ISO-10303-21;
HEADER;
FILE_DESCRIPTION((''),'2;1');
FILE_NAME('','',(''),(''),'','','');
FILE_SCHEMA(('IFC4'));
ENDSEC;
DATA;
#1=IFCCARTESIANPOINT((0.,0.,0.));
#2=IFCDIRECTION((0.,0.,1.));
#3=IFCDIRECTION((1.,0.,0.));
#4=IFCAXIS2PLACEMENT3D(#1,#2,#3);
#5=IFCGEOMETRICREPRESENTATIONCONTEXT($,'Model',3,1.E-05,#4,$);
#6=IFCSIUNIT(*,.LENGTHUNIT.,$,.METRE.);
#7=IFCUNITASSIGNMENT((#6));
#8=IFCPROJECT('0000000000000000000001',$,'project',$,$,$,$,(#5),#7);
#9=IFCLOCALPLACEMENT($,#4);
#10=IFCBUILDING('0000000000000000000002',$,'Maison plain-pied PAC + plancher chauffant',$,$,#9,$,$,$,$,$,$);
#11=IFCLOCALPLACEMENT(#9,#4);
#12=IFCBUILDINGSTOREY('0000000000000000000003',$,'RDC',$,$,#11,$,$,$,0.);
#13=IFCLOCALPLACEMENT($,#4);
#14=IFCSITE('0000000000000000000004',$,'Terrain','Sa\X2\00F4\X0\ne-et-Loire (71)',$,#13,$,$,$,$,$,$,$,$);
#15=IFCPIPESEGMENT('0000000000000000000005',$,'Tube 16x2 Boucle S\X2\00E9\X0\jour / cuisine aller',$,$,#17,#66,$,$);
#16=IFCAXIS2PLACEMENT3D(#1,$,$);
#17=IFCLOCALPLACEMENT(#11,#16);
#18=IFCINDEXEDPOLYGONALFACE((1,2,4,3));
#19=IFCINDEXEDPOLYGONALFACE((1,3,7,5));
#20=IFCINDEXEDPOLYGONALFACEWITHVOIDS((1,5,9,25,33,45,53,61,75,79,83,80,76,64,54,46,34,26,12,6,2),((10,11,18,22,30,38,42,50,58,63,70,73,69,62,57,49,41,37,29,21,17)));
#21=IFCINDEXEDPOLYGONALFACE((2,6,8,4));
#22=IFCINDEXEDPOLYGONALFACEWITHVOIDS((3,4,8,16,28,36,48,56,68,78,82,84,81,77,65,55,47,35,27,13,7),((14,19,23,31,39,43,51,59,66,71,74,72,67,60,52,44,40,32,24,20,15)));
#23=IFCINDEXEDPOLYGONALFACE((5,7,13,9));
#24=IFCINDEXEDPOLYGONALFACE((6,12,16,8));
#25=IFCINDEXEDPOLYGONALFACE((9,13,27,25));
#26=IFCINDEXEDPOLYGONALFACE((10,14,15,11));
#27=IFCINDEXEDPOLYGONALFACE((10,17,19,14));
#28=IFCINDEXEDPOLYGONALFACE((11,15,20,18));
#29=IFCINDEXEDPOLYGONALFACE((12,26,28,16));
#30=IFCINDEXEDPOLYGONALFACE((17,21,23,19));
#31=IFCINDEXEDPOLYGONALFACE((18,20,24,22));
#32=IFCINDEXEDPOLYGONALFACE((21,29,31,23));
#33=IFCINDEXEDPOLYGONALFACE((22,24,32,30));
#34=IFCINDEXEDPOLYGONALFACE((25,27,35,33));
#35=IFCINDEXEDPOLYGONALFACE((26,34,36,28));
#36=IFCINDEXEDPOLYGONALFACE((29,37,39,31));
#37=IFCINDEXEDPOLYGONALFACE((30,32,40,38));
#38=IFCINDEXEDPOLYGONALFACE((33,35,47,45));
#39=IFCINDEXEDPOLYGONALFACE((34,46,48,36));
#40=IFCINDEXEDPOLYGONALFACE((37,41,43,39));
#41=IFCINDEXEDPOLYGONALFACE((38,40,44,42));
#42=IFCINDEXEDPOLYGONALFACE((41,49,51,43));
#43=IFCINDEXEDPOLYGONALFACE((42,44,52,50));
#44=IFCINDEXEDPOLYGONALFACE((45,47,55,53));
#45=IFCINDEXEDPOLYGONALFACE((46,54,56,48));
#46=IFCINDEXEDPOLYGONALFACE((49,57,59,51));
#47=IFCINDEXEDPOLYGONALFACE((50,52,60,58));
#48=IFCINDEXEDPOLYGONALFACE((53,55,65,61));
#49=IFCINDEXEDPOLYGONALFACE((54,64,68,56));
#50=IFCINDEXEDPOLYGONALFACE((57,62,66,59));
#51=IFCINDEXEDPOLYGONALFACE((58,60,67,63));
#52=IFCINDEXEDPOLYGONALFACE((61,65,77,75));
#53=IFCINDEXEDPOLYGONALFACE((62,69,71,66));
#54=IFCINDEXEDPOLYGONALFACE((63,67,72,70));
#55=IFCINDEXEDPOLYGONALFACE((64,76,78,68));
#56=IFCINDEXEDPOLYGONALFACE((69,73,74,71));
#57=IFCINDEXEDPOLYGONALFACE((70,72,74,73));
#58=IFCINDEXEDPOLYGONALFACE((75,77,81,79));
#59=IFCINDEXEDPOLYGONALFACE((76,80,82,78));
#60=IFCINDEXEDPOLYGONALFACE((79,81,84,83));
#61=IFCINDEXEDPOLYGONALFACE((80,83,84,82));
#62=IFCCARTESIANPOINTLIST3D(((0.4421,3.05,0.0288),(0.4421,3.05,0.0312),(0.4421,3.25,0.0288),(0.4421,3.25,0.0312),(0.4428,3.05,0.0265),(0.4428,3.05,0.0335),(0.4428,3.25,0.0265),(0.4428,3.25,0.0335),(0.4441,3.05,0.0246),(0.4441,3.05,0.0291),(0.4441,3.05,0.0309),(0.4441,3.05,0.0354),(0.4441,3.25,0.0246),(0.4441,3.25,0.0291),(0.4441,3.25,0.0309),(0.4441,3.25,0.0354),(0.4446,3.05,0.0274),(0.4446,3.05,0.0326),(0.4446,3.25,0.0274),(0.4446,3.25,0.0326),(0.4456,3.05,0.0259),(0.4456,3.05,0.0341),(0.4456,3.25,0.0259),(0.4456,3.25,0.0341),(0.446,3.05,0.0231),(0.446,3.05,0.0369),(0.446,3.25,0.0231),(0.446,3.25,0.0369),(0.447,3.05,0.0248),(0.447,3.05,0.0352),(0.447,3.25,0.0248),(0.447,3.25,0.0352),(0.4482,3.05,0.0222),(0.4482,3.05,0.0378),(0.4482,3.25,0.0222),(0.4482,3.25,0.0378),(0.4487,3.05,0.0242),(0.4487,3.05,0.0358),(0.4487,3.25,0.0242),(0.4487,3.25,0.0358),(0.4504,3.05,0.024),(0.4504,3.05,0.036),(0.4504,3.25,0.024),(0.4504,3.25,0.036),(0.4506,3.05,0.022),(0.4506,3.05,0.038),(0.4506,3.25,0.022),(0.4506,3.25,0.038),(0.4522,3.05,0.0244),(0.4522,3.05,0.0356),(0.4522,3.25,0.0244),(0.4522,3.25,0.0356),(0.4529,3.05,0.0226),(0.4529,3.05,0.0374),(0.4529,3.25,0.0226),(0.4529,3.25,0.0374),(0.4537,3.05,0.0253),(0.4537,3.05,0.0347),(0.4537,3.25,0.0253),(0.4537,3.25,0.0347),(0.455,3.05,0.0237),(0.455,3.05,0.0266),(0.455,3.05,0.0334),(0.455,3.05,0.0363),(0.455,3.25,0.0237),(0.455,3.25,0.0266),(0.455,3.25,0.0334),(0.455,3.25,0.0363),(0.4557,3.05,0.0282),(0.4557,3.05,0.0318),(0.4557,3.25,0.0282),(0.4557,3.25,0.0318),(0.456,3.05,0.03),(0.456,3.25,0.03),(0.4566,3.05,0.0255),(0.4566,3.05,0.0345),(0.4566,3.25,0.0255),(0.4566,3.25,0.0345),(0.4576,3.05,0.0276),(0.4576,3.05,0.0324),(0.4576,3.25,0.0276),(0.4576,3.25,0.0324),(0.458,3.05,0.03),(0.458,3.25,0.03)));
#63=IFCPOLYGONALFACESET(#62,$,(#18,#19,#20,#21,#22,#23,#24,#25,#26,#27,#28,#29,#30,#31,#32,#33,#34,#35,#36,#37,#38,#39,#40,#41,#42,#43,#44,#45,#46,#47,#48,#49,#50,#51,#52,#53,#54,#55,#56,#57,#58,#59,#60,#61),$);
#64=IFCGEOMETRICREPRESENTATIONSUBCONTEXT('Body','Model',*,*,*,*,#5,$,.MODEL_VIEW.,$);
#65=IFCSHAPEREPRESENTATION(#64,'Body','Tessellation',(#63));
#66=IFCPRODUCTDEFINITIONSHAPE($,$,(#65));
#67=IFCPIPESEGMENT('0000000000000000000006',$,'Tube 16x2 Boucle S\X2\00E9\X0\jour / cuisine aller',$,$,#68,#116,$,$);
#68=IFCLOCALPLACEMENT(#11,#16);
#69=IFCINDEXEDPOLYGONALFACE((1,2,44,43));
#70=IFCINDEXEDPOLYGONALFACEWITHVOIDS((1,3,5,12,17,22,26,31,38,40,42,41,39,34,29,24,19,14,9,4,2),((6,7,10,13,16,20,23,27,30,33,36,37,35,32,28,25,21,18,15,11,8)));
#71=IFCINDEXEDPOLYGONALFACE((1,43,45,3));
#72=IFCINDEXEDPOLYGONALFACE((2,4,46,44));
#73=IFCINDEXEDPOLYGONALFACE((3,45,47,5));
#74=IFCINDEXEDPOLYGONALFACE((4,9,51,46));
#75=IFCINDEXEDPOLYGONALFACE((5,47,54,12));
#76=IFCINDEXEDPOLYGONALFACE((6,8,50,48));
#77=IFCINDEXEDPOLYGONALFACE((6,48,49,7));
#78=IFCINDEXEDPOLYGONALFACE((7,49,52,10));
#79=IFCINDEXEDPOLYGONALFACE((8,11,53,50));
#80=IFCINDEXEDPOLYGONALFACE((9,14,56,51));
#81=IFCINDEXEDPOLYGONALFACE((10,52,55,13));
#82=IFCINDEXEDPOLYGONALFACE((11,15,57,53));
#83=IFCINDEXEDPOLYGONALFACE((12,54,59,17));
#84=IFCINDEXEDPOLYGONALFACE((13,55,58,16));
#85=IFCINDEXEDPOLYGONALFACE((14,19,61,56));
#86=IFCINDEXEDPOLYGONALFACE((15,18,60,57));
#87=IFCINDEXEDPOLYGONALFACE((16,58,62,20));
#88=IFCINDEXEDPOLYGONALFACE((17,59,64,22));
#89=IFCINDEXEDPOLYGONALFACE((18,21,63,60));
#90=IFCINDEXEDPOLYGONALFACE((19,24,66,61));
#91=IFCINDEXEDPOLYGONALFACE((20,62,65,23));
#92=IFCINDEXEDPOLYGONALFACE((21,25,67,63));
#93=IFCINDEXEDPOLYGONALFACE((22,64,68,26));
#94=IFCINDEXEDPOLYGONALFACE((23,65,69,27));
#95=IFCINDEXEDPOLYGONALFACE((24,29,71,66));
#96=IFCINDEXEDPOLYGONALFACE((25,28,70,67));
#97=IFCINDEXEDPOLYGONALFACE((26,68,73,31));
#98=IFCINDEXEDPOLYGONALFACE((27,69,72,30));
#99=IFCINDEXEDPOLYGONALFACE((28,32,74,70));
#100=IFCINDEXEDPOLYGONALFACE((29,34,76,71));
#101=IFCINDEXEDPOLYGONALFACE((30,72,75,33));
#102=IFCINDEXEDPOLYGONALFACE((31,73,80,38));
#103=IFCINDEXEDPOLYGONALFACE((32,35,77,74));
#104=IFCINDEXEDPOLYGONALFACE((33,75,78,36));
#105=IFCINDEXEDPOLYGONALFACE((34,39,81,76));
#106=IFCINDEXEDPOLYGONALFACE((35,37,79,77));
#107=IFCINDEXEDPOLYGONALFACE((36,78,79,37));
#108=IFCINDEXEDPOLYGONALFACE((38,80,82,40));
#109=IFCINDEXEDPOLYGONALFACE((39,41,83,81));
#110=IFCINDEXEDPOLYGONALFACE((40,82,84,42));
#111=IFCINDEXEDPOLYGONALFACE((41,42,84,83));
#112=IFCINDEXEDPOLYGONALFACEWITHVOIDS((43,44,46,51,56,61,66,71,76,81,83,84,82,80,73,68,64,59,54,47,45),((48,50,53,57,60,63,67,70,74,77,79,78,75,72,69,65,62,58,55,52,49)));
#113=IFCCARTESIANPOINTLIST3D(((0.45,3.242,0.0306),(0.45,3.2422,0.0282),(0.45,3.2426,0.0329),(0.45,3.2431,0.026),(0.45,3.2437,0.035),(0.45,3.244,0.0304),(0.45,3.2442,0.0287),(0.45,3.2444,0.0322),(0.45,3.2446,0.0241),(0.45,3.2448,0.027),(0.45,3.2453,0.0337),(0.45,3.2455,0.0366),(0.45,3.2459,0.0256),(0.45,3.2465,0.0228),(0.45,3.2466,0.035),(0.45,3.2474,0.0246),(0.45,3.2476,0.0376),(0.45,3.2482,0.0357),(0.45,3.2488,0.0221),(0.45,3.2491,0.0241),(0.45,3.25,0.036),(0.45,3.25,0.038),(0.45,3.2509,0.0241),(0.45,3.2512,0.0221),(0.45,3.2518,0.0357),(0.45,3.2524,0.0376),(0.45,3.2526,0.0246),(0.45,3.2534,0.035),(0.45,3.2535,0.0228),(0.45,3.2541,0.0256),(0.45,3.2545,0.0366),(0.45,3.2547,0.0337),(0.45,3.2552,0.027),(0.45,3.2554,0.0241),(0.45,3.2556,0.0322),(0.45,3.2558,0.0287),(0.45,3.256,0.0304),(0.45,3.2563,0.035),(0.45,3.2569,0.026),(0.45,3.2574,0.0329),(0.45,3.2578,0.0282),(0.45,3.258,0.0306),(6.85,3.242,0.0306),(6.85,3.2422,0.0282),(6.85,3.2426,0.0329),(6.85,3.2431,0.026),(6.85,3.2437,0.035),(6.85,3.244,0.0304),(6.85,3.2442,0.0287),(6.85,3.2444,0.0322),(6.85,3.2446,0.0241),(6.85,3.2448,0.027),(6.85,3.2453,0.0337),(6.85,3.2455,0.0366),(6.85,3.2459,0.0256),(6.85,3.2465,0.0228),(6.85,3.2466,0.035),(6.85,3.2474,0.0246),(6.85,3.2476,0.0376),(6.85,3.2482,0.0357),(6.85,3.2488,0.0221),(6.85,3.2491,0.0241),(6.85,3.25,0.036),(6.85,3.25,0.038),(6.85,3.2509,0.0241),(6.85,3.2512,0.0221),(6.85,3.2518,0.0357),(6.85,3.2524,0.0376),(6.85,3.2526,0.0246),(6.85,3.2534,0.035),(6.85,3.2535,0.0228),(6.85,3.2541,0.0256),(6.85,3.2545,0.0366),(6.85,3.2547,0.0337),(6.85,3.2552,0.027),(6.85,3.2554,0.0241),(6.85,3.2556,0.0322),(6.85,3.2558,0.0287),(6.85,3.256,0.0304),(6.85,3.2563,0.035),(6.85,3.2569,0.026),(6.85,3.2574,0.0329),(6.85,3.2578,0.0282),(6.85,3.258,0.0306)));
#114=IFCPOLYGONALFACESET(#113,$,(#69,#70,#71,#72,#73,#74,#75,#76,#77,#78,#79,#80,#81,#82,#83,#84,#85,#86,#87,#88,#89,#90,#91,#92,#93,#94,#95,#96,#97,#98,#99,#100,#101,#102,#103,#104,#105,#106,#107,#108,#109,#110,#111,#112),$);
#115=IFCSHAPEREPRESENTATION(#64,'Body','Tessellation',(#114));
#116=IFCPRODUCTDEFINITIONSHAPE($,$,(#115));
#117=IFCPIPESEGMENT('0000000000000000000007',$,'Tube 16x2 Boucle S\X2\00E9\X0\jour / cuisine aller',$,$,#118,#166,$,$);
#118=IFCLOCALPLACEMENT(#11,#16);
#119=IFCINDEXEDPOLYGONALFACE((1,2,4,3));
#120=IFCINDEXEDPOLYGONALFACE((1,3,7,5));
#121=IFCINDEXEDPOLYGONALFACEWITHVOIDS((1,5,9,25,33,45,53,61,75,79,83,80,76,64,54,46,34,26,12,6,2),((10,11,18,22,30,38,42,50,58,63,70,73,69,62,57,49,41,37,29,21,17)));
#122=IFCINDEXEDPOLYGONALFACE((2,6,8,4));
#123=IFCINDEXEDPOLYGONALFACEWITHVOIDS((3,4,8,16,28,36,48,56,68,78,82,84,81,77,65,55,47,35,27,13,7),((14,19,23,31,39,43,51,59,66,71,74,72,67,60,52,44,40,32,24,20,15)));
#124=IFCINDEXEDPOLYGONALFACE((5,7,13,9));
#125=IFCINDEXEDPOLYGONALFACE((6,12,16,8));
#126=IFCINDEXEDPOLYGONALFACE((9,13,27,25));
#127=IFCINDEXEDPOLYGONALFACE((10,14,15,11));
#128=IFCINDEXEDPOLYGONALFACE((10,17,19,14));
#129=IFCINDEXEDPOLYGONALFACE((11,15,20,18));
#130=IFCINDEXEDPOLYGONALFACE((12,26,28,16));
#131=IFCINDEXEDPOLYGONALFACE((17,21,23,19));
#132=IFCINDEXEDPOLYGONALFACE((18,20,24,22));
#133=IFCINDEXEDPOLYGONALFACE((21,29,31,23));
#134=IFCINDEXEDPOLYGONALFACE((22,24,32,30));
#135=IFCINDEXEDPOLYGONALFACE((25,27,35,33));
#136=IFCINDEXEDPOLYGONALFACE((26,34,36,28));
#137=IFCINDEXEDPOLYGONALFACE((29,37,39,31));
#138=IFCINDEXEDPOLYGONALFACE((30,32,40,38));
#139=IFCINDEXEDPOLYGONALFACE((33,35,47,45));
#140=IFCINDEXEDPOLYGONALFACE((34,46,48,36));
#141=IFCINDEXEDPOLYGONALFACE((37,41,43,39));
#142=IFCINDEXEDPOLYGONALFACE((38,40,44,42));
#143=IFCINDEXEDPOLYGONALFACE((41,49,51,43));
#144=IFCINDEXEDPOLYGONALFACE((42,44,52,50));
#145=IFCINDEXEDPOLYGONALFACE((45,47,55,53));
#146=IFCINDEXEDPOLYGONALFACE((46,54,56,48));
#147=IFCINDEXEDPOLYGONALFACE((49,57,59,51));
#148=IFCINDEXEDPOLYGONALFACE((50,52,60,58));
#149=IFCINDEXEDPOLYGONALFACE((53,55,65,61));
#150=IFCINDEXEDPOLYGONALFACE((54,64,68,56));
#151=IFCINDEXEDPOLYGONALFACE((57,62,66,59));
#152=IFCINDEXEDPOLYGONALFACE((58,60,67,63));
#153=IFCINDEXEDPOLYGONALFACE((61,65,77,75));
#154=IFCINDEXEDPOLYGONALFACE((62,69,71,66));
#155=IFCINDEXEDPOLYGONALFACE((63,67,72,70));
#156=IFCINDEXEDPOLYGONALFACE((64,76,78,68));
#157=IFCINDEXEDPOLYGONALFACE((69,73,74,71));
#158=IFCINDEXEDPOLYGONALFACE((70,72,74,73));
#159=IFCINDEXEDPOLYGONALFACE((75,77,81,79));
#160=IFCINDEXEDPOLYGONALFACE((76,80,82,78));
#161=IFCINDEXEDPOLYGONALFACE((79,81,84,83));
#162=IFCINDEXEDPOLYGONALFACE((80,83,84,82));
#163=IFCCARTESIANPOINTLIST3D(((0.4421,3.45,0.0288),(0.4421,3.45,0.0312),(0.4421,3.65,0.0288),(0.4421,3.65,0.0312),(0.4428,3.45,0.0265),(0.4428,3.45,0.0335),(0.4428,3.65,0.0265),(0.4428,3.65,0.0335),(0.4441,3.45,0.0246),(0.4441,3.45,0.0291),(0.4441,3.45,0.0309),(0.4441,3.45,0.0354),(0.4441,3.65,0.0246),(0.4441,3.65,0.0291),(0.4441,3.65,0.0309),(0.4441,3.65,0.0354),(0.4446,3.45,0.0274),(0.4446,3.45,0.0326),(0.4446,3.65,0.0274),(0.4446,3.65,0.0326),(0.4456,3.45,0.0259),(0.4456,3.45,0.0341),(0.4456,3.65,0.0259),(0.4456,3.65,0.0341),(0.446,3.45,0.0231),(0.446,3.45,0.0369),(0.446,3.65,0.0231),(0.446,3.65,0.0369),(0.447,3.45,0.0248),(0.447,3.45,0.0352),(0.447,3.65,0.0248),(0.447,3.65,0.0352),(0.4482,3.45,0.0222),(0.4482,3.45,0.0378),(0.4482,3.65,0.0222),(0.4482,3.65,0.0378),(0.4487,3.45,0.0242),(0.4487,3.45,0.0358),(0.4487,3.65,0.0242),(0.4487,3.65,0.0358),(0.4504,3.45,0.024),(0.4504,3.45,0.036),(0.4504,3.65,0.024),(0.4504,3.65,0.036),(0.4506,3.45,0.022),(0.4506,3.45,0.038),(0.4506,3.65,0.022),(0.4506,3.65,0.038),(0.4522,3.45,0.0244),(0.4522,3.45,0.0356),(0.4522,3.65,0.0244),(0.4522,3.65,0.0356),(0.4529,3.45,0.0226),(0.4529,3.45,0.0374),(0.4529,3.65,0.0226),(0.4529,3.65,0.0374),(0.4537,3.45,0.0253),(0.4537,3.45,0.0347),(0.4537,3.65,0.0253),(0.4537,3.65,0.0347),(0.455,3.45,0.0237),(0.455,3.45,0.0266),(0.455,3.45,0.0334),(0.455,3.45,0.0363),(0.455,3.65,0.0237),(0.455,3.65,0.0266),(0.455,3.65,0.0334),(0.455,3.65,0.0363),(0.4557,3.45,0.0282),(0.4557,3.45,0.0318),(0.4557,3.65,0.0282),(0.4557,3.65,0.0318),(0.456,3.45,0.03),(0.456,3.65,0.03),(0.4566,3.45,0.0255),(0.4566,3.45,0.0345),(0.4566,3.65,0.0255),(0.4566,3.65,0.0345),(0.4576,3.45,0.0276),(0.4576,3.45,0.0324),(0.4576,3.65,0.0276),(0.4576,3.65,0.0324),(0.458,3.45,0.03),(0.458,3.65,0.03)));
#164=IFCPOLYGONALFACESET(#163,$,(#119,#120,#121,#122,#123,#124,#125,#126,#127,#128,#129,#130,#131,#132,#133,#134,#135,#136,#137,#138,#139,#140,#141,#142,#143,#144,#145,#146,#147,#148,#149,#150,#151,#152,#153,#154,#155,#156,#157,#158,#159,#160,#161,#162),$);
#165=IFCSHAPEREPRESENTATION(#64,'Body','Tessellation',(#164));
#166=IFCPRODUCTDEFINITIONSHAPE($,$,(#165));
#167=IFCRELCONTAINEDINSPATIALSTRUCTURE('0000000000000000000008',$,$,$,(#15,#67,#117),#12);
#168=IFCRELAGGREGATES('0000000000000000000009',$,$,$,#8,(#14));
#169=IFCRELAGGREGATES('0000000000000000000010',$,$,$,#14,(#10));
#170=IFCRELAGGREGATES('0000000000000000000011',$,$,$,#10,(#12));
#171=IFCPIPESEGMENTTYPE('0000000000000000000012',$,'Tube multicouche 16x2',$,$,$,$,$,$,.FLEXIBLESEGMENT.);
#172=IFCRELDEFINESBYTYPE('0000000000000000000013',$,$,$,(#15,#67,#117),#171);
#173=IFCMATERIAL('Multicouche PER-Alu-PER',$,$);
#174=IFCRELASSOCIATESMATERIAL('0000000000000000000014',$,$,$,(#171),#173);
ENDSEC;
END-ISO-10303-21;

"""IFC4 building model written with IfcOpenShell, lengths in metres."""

from ifc_helpers import new_model, si_unit, frame, origin_with_axes, place, context, subcontext, project, spatial, hollow_circle, extrude, material, type_object, element, save


model = new_model("IFC4")

# Units and contexts
model_context = context("Model", 3, precision=1e-05, world=origin_with_axes())
body_context = subcontext(model_context, "Body", "Model", "MODEL_VIEW")
ifc_project = project(units=[si_unit("LENGTHUNIT", "METRE")], contexts=[model_context])

# Site, building, storey
site_placement = place(None, origin_with_axes())
site = spatial("IfcSite", under=ifc_project, at=site_placement, Name="Terrain", Description="Saône-et-Loire (71)")
building_placement = place(None, origin_with_axes())
building = spatial("IfcBuilding", under=site, at=building_placement, Name="Maison plain-pied PAC + plancher chauffant")
storey_placement = place(building_placement, origin_with_axes())
storey = spatial("IfcBuildingStorey", under=building, at=storey_placement, Name="RDC", Elevation=0.0)

# Pipe segments
ifc_material = material(Name="Multicouche PER-Alu-PER")
pipe_segment_type = type_object("IfcPipeSegmentType", Name="Tube multicouche 16x2", PredefinedType="FLEXIBLESEGMENT", material=ifc_material)
pipe_segment_1_placement = place(storey_placement, frame((0.45, 3.05, 0.03), z_axis=(0.0, 1.0, 0.0), x_axis=(1.0, 0.0, 0.0)))
element("IfcPipeSegment", 1, at=pipe_segment_1_placement, inside=storey, type_object=pipe_segment_type, Name="Tube 16x2 Boucle Séjour / cuisine aller", context=body_context, shape_type="SweptSolid", body=[
    extrude(hollow_circle(Radius=0.008, WallThickness=0.002), origin_with_axes(), (0.0, 0.0, 1.0), 0.2),
])
pipe_segment_2_placement = place(storey_placement, frame((0.45, 3.25, 0.03), z_axis=(1.0, 0.0, 0.0), x_axis=(0.0, 0.0, 1.0)))
element("IfcPipeSegment", 2, at=pipe_segment_2_placement, inside=storey, type_object=pipe_segment_type, Name="Tube 16x2 Boucle Séjour / cuisine aller", context=body_context, shape_type="SweptSolid", body=[
    extrude(hollow_circle(Radius=0.008, WallThickness=0.002), origin_with_axes(), (0.0, 0.0, 1.0), 6.4),
])
pipe_segment_3_placement = place(storey_placement, frame((0.45, 3.45, 0.03), z_axis=(0.0, 1.0, 0.0), x_axis=(1.0, 0.0, 0.0)))
element("IfcPipeSegment", 3, at=pipe_segment_3_placement, inside=storey, type_object=pipe_segment_type, Name="Tube 16x2 Boucle Séjour / cuisine aller", context=body_context, shape_type="SweptSolid", body=[
    extrude(hollow_circle(Radius=0.008, WallThickness=0.002), origin_with_axes(), (0.0, 0.0, 1.0), 0.2),
])

save(model, "model.ifc")
